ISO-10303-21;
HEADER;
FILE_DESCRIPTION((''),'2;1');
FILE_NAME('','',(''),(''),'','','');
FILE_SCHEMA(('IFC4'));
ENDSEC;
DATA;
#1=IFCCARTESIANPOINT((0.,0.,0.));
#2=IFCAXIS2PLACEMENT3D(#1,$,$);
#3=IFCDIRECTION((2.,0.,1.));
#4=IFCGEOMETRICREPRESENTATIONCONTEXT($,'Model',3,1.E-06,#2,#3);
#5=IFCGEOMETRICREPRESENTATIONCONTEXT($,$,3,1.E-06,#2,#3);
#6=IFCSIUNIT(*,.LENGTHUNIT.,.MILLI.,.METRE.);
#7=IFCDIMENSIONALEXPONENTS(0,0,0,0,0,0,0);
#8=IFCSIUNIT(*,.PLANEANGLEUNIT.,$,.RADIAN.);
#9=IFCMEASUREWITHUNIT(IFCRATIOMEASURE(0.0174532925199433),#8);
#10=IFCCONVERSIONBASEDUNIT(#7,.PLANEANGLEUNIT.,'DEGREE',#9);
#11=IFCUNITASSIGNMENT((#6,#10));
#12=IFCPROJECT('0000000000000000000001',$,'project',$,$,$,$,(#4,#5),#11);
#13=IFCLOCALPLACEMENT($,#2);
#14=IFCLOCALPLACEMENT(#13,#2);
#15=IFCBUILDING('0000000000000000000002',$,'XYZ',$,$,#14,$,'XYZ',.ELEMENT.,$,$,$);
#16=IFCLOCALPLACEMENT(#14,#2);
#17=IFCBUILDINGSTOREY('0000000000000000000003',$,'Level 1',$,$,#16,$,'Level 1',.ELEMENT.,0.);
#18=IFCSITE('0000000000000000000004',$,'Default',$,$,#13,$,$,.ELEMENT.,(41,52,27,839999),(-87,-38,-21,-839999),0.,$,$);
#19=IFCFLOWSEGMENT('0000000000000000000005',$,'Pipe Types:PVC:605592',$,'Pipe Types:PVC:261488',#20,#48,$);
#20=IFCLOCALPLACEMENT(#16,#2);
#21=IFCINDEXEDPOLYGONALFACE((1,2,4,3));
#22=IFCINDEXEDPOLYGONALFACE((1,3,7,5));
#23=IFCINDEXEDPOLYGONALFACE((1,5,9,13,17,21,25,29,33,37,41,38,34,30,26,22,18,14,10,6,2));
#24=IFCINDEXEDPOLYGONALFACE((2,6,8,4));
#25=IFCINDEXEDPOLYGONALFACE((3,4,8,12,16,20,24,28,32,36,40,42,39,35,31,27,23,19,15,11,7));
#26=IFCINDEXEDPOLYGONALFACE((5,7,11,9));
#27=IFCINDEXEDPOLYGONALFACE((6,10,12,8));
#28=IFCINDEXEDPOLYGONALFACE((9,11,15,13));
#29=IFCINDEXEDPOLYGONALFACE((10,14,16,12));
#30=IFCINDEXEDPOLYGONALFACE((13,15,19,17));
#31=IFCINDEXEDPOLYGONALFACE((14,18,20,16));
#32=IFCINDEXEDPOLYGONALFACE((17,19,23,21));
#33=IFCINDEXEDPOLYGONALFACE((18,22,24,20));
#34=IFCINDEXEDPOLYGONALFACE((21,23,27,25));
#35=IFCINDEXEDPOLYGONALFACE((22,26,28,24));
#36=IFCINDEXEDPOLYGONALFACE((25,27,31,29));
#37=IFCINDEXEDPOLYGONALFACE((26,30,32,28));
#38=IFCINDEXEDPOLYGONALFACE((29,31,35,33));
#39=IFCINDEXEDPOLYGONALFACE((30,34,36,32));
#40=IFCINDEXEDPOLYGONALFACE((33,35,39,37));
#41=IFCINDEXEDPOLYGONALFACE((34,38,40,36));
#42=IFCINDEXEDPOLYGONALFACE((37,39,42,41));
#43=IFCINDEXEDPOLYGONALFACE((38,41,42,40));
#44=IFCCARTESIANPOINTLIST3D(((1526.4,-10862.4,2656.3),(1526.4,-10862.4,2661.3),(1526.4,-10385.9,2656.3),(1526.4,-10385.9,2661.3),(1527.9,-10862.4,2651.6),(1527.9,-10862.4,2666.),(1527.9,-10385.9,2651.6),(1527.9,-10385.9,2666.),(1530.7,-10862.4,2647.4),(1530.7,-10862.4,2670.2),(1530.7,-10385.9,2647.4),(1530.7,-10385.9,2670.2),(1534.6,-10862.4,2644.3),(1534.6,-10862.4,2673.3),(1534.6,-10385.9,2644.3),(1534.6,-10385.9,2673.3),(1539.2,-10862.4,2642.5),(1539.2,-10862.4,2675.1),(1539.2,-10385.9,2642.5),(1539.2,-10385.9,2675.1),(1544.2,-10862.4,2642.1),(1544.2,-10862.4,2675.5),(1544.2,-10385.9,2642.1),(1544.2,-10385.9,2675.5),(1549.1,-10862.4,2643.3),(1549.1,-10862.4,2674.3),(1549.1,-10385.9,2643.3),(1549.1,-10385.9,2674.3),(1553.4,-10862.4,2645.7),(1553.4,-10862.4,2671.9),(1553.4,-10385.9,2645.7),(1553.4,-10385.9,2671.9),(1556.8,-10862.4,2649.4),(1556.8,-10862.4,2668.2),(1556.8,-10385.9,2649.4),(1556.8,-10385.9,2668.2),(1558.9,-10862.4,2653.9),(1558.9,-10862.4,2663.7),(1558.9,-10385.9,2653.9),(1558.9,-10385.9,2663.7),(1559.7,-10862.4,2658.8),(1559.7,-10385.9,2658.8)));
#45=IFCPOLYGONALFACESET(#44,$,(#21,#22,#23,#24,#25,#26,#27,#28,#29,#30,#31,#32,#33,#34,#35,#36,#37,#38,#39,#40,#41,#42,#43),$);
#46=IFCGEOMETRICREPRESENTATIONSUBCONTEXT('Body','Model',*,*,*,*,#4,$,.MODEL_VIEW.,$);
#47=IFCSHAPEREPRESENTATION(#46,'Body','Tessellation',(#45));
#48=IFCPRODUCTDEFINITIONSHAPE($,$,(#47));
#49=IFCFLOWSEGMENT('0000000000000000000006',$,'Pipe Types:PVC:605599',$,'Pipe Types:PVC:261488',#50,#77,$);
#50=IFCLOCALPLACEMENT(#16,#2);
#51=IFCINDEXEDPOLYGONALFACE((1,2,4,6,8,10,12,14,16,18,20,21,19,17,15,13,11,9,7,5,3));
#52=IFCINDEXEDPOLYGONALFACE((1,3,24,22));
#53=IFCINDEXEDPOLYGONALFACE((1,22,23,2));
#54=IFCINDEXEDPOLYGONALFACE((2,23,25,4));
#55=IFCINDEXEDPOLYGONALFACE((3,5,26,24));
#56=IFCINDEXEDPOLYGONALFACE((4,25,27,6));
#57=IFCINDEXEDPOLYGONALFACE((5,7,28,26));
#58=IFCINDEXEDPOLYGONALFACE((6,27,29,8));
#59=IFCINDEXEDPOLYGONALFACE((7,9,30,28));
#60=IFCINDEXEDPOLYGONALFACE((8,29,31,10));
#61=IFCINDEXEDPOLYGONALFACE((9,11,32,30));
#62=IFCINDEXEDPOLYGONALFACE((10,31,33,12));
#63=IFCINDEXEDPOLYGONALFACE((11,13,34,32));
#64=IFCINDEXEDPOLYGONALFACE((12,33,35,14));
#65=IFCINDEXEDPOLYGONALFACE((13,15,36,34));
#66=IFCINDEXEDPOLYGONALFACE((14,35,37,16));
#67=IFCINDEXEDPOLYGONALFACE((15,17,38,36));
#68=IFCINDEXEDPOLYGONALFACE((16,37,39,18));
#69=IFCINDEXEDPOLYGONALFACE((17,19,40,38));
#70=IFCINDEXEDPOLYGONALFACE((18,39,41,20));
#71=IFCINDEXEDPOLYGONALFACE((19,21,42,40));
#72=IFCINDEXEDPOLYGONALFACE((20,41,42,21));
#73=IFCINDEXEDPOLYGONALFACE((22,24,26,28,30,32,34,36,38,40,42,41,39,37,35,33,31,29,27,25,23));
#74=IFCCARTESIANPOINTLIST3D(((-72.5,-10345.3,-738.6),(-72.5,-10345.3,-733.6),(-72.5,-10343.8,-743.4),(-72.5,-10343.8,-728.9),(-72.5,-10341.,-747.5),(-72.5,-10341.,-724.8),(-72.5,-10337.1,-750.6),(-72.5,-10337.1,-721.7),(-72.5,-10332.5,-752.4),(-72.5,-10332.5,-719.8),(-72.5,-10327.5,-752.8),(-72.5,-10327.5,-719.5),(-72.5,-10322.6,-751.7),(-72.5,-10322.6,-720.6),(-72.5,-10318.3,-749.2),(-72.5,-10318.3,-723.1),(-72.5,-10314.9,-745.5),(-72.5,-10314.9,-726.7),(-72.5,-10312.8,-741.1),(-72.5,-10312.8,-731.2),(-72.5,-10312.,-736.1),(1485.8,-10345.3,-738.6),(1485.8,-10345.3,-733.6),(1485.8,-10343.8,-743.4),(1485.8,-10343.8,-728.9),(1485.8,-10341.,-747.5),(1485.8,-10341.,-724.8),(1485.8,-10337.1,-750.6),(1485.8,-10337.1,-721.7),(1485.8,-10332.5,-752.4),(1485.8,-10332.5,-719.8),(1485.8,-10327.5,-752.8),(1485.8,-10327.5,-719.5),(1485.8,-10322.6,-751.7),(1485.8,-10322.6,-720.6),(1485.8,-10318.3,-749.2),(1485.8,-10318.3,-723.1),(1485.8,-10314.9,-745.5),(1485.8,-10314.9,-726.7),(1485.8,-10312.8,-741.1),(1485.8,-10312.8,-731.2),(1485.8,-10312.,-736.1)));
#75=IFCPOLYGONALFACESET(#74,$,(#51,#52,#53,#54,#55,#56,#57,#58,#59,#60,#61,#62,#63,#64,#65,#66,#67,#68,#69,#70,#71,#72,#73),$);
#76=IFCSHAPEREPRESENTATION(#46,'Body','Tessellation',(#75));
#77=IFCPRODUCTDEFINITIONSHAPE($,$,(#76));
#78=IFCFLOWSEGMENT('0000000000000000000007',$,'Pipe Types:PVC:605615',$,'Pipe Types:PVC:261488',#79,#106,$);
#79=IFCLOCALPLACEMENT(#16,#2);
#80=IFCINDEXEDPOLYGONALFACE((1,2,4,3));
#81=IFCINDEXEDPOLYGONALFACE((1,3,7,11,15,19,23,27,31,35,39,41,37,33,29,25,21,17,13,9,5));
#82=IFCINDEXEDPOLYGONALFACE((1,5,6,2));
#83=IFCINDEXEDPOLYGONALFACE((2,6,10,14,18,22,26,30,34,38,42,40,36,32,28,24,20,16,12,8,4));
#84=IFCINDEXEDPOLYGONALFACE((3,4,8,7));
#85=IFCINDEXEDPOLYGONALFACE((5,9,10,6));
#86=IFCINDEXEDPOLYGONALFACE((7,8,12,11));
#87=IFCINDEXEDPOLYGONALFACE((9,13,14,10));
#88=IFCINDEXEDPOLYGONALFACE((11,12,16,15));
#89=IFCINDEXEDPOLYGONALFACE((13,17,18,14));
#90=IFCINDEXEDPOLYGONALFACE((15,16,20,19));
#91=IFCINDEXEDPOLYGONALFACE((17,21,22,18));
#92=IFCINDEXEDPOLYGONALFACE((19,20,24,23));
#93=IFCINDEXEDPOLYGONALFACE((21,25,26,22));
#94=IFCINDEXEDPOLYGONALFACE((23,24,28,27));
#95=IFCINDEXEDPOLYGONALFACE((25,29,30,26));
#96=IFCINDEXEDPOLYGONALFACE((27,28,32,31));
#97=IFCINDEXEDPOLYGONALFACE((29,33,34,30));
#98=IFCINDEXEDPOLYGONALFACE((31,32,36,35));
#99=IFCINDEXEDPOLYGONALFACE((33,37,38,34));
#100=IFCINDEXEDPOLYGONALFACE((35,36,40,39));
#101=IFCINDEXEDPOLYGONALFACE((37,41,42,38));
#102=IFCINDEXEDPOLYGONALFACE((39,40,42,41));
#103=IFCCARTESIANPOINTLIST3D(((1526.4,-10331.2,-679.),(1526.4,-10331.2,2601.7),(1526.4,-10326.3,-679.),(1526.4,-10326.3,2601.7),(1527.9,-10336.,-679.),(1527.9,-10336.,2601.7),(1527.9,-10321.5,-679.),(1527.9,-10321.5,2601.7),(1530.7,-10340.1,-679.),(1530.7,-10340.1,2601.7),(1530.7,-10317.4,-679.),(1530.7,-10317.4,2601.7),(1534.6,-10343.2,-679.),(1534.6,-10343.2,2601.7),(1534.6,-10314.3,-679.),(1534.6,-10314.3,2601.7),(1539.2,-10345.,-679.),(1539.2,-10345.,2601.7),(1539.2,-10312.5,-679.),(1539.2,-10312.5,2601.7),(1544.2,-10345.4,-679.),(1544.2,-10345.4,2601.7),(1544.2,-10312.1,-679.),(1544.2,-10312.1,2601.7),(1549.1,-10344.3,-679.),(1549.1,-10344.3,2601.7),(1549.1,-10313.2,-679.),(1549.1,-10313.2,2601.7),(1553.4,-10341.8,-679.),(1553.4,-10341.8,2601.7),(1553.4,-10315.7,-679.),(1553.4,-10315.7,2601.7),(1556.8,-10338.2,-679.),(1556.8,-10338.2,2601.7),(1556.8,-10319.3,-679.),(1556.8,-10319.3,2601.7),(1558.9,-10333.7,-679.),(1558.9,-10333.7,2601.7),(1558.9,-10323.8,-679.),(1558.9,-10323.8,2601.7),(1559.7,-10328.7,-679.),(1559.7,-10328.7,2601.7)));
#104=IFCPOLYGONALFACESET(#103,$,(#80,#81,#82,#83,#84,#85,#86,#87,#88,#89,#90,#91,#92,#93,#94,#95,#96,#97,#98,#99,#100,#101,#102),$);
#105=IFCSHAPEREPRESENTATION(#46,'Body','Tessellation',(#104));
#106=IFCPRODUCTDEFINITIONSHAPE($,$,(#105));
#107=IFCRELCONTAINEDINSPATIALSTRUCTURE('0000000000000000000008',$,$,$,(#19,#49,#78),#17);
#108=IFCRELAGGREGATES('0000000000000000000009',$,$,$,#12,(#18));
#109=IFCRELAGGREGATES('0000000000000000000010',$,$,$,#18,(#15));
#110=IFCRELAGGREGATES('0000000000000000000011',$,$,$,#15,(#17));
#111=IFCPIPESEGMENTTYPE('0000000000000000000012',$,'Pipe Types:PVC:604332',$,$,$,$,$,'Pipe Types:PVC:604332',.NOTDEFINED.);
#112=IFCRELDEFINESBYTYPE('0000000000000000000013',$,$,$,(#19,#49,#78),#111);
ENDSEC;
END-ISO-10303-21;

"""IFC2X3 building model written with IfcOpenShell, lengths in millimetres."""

from ifc_helpers import new_model, entity, si_unit, converted_unit, direction, frame, frame_2d, origin, origin_2d_with_axis, place, context, subcontext, project, spatial, circle, extrude, type_object, element, save


model = new_model("IFC2X3")

# Units and contexts
model_context = context("Model", 3, precision=1e-06, world=origin(), true_north=direction((2.0, 0.0, 1.0)))
context_of_model = context(None, 3, precision=1e-06, world=origin(), true_north=direction((2.0, 0.0, 1.0)))
body_context = subcontext(model_context, "Body", "Model", "MODEL_VIEW")
ifc_project = project(units=[si_unit("LENGTHUNIT", "METRE", prefix="MILLI"), converted_unit("PLANEANGLEUNIT", "DEGREE", entity("IfcRatioMeasure", 0.0174532925199433), si_unit("PLANEANGLEUNIT", "RADIAN"), dimensions=[0, 0, 0, 0, 0, 0, 0])], contexts=[model_context, context_of_model])

# Site, building, storey
site_placement = place(None, origin())
site = spatial("IfcSite", under=ifc_project, at=site_placement, Name="Default", CompositionType="ELEMENT", RefLatitude=(41, 52, 27, 839999), RefLongitude=(-87, -38, -21, -839999), RefElevation=0.0)
building_placement = place(site_placement, origin())
building = spatial("IfcBuilding", under=site, at=building_placement, Name="XYZ", LongName="XYZ", CompositionType="ELEMENT")
storey_placement = place(building_placement, origin())
storey = spatial("IfcBuildingStorey", under=building, at=storey_placement, Name="Level 1", LongName="Level 1", CompositionType="ELEMENT", Elevation=0.0)

# Flow segments
pipe_segment_type_1 = type_object("IfcPipeSegmentType", Name="Pipe Types:PVC:604332", ElementType="Pipe Types:PVC:604332", PredefinedType="NOTDEFINED")
flow_segment_1_placement = place(storey_placement, origin())
element("IfcFlowSegment", 1, at=flow_segment_1_placement, inside=storey, type_object=pipe_segment_type_1, Name="Pipe Types:PVC:605592", ObjectType="Pipe Types:PVC:261488", context=body_context, shape_type="SweptSolid", body=[
    extrude(circle(Radius=16.7, at=origin_2d_with_axis()), frame((1543.0, -10862.4, 2658.8), z_axis=(0.0, 1.0, 0.0), x_axis=(1.0, 0.0, 0.0)), (0.0, 0.0, 1.0), 476.5),
])
flow_segment_2_placement = place(storey_placement, origin())
element("IfcFlowSegment", 2, at=flow_segment_2_placement, inside=storey, type_object=pipe_segment_type_1, Name="Pipe Types:PVC:605599", ObjectType="Pipe Types:PVC:261488", context=body_context, shape_type="SweptSolid", body=[
    extrude(circle(Radius=16.7, at=frame_2d((0.0, 0.0), x_axis=(1.0, 0.0))), frame((-72.5, -10328.7, -736.1), z_axis=(1.0, 0.0, 0.0), x_axis=(0.0, 1.0, 0.0)), (0.0, 0.0, 1.0), 1558.3),
])
flow_segment_3_placement = place(storey_placement, origin())
element("IfcFlowSegment", 3, at=flow_segment_3_placement, inside=storey, type_object=pipe_segment_type_1, Name="Pipe Types:PVC:605615", ObjectType="Pipe Types:PVC:261488", context=body_context, shape_type="SweptSolid", body=[
    extrude(circle(Radius=16.7, at=origin_2d_with_axis()), frame((1543.0, -10328.7, -679.0)), (0.0, 0.0, 1.0), 3280.6),
])

save(model, "model.ifc")
